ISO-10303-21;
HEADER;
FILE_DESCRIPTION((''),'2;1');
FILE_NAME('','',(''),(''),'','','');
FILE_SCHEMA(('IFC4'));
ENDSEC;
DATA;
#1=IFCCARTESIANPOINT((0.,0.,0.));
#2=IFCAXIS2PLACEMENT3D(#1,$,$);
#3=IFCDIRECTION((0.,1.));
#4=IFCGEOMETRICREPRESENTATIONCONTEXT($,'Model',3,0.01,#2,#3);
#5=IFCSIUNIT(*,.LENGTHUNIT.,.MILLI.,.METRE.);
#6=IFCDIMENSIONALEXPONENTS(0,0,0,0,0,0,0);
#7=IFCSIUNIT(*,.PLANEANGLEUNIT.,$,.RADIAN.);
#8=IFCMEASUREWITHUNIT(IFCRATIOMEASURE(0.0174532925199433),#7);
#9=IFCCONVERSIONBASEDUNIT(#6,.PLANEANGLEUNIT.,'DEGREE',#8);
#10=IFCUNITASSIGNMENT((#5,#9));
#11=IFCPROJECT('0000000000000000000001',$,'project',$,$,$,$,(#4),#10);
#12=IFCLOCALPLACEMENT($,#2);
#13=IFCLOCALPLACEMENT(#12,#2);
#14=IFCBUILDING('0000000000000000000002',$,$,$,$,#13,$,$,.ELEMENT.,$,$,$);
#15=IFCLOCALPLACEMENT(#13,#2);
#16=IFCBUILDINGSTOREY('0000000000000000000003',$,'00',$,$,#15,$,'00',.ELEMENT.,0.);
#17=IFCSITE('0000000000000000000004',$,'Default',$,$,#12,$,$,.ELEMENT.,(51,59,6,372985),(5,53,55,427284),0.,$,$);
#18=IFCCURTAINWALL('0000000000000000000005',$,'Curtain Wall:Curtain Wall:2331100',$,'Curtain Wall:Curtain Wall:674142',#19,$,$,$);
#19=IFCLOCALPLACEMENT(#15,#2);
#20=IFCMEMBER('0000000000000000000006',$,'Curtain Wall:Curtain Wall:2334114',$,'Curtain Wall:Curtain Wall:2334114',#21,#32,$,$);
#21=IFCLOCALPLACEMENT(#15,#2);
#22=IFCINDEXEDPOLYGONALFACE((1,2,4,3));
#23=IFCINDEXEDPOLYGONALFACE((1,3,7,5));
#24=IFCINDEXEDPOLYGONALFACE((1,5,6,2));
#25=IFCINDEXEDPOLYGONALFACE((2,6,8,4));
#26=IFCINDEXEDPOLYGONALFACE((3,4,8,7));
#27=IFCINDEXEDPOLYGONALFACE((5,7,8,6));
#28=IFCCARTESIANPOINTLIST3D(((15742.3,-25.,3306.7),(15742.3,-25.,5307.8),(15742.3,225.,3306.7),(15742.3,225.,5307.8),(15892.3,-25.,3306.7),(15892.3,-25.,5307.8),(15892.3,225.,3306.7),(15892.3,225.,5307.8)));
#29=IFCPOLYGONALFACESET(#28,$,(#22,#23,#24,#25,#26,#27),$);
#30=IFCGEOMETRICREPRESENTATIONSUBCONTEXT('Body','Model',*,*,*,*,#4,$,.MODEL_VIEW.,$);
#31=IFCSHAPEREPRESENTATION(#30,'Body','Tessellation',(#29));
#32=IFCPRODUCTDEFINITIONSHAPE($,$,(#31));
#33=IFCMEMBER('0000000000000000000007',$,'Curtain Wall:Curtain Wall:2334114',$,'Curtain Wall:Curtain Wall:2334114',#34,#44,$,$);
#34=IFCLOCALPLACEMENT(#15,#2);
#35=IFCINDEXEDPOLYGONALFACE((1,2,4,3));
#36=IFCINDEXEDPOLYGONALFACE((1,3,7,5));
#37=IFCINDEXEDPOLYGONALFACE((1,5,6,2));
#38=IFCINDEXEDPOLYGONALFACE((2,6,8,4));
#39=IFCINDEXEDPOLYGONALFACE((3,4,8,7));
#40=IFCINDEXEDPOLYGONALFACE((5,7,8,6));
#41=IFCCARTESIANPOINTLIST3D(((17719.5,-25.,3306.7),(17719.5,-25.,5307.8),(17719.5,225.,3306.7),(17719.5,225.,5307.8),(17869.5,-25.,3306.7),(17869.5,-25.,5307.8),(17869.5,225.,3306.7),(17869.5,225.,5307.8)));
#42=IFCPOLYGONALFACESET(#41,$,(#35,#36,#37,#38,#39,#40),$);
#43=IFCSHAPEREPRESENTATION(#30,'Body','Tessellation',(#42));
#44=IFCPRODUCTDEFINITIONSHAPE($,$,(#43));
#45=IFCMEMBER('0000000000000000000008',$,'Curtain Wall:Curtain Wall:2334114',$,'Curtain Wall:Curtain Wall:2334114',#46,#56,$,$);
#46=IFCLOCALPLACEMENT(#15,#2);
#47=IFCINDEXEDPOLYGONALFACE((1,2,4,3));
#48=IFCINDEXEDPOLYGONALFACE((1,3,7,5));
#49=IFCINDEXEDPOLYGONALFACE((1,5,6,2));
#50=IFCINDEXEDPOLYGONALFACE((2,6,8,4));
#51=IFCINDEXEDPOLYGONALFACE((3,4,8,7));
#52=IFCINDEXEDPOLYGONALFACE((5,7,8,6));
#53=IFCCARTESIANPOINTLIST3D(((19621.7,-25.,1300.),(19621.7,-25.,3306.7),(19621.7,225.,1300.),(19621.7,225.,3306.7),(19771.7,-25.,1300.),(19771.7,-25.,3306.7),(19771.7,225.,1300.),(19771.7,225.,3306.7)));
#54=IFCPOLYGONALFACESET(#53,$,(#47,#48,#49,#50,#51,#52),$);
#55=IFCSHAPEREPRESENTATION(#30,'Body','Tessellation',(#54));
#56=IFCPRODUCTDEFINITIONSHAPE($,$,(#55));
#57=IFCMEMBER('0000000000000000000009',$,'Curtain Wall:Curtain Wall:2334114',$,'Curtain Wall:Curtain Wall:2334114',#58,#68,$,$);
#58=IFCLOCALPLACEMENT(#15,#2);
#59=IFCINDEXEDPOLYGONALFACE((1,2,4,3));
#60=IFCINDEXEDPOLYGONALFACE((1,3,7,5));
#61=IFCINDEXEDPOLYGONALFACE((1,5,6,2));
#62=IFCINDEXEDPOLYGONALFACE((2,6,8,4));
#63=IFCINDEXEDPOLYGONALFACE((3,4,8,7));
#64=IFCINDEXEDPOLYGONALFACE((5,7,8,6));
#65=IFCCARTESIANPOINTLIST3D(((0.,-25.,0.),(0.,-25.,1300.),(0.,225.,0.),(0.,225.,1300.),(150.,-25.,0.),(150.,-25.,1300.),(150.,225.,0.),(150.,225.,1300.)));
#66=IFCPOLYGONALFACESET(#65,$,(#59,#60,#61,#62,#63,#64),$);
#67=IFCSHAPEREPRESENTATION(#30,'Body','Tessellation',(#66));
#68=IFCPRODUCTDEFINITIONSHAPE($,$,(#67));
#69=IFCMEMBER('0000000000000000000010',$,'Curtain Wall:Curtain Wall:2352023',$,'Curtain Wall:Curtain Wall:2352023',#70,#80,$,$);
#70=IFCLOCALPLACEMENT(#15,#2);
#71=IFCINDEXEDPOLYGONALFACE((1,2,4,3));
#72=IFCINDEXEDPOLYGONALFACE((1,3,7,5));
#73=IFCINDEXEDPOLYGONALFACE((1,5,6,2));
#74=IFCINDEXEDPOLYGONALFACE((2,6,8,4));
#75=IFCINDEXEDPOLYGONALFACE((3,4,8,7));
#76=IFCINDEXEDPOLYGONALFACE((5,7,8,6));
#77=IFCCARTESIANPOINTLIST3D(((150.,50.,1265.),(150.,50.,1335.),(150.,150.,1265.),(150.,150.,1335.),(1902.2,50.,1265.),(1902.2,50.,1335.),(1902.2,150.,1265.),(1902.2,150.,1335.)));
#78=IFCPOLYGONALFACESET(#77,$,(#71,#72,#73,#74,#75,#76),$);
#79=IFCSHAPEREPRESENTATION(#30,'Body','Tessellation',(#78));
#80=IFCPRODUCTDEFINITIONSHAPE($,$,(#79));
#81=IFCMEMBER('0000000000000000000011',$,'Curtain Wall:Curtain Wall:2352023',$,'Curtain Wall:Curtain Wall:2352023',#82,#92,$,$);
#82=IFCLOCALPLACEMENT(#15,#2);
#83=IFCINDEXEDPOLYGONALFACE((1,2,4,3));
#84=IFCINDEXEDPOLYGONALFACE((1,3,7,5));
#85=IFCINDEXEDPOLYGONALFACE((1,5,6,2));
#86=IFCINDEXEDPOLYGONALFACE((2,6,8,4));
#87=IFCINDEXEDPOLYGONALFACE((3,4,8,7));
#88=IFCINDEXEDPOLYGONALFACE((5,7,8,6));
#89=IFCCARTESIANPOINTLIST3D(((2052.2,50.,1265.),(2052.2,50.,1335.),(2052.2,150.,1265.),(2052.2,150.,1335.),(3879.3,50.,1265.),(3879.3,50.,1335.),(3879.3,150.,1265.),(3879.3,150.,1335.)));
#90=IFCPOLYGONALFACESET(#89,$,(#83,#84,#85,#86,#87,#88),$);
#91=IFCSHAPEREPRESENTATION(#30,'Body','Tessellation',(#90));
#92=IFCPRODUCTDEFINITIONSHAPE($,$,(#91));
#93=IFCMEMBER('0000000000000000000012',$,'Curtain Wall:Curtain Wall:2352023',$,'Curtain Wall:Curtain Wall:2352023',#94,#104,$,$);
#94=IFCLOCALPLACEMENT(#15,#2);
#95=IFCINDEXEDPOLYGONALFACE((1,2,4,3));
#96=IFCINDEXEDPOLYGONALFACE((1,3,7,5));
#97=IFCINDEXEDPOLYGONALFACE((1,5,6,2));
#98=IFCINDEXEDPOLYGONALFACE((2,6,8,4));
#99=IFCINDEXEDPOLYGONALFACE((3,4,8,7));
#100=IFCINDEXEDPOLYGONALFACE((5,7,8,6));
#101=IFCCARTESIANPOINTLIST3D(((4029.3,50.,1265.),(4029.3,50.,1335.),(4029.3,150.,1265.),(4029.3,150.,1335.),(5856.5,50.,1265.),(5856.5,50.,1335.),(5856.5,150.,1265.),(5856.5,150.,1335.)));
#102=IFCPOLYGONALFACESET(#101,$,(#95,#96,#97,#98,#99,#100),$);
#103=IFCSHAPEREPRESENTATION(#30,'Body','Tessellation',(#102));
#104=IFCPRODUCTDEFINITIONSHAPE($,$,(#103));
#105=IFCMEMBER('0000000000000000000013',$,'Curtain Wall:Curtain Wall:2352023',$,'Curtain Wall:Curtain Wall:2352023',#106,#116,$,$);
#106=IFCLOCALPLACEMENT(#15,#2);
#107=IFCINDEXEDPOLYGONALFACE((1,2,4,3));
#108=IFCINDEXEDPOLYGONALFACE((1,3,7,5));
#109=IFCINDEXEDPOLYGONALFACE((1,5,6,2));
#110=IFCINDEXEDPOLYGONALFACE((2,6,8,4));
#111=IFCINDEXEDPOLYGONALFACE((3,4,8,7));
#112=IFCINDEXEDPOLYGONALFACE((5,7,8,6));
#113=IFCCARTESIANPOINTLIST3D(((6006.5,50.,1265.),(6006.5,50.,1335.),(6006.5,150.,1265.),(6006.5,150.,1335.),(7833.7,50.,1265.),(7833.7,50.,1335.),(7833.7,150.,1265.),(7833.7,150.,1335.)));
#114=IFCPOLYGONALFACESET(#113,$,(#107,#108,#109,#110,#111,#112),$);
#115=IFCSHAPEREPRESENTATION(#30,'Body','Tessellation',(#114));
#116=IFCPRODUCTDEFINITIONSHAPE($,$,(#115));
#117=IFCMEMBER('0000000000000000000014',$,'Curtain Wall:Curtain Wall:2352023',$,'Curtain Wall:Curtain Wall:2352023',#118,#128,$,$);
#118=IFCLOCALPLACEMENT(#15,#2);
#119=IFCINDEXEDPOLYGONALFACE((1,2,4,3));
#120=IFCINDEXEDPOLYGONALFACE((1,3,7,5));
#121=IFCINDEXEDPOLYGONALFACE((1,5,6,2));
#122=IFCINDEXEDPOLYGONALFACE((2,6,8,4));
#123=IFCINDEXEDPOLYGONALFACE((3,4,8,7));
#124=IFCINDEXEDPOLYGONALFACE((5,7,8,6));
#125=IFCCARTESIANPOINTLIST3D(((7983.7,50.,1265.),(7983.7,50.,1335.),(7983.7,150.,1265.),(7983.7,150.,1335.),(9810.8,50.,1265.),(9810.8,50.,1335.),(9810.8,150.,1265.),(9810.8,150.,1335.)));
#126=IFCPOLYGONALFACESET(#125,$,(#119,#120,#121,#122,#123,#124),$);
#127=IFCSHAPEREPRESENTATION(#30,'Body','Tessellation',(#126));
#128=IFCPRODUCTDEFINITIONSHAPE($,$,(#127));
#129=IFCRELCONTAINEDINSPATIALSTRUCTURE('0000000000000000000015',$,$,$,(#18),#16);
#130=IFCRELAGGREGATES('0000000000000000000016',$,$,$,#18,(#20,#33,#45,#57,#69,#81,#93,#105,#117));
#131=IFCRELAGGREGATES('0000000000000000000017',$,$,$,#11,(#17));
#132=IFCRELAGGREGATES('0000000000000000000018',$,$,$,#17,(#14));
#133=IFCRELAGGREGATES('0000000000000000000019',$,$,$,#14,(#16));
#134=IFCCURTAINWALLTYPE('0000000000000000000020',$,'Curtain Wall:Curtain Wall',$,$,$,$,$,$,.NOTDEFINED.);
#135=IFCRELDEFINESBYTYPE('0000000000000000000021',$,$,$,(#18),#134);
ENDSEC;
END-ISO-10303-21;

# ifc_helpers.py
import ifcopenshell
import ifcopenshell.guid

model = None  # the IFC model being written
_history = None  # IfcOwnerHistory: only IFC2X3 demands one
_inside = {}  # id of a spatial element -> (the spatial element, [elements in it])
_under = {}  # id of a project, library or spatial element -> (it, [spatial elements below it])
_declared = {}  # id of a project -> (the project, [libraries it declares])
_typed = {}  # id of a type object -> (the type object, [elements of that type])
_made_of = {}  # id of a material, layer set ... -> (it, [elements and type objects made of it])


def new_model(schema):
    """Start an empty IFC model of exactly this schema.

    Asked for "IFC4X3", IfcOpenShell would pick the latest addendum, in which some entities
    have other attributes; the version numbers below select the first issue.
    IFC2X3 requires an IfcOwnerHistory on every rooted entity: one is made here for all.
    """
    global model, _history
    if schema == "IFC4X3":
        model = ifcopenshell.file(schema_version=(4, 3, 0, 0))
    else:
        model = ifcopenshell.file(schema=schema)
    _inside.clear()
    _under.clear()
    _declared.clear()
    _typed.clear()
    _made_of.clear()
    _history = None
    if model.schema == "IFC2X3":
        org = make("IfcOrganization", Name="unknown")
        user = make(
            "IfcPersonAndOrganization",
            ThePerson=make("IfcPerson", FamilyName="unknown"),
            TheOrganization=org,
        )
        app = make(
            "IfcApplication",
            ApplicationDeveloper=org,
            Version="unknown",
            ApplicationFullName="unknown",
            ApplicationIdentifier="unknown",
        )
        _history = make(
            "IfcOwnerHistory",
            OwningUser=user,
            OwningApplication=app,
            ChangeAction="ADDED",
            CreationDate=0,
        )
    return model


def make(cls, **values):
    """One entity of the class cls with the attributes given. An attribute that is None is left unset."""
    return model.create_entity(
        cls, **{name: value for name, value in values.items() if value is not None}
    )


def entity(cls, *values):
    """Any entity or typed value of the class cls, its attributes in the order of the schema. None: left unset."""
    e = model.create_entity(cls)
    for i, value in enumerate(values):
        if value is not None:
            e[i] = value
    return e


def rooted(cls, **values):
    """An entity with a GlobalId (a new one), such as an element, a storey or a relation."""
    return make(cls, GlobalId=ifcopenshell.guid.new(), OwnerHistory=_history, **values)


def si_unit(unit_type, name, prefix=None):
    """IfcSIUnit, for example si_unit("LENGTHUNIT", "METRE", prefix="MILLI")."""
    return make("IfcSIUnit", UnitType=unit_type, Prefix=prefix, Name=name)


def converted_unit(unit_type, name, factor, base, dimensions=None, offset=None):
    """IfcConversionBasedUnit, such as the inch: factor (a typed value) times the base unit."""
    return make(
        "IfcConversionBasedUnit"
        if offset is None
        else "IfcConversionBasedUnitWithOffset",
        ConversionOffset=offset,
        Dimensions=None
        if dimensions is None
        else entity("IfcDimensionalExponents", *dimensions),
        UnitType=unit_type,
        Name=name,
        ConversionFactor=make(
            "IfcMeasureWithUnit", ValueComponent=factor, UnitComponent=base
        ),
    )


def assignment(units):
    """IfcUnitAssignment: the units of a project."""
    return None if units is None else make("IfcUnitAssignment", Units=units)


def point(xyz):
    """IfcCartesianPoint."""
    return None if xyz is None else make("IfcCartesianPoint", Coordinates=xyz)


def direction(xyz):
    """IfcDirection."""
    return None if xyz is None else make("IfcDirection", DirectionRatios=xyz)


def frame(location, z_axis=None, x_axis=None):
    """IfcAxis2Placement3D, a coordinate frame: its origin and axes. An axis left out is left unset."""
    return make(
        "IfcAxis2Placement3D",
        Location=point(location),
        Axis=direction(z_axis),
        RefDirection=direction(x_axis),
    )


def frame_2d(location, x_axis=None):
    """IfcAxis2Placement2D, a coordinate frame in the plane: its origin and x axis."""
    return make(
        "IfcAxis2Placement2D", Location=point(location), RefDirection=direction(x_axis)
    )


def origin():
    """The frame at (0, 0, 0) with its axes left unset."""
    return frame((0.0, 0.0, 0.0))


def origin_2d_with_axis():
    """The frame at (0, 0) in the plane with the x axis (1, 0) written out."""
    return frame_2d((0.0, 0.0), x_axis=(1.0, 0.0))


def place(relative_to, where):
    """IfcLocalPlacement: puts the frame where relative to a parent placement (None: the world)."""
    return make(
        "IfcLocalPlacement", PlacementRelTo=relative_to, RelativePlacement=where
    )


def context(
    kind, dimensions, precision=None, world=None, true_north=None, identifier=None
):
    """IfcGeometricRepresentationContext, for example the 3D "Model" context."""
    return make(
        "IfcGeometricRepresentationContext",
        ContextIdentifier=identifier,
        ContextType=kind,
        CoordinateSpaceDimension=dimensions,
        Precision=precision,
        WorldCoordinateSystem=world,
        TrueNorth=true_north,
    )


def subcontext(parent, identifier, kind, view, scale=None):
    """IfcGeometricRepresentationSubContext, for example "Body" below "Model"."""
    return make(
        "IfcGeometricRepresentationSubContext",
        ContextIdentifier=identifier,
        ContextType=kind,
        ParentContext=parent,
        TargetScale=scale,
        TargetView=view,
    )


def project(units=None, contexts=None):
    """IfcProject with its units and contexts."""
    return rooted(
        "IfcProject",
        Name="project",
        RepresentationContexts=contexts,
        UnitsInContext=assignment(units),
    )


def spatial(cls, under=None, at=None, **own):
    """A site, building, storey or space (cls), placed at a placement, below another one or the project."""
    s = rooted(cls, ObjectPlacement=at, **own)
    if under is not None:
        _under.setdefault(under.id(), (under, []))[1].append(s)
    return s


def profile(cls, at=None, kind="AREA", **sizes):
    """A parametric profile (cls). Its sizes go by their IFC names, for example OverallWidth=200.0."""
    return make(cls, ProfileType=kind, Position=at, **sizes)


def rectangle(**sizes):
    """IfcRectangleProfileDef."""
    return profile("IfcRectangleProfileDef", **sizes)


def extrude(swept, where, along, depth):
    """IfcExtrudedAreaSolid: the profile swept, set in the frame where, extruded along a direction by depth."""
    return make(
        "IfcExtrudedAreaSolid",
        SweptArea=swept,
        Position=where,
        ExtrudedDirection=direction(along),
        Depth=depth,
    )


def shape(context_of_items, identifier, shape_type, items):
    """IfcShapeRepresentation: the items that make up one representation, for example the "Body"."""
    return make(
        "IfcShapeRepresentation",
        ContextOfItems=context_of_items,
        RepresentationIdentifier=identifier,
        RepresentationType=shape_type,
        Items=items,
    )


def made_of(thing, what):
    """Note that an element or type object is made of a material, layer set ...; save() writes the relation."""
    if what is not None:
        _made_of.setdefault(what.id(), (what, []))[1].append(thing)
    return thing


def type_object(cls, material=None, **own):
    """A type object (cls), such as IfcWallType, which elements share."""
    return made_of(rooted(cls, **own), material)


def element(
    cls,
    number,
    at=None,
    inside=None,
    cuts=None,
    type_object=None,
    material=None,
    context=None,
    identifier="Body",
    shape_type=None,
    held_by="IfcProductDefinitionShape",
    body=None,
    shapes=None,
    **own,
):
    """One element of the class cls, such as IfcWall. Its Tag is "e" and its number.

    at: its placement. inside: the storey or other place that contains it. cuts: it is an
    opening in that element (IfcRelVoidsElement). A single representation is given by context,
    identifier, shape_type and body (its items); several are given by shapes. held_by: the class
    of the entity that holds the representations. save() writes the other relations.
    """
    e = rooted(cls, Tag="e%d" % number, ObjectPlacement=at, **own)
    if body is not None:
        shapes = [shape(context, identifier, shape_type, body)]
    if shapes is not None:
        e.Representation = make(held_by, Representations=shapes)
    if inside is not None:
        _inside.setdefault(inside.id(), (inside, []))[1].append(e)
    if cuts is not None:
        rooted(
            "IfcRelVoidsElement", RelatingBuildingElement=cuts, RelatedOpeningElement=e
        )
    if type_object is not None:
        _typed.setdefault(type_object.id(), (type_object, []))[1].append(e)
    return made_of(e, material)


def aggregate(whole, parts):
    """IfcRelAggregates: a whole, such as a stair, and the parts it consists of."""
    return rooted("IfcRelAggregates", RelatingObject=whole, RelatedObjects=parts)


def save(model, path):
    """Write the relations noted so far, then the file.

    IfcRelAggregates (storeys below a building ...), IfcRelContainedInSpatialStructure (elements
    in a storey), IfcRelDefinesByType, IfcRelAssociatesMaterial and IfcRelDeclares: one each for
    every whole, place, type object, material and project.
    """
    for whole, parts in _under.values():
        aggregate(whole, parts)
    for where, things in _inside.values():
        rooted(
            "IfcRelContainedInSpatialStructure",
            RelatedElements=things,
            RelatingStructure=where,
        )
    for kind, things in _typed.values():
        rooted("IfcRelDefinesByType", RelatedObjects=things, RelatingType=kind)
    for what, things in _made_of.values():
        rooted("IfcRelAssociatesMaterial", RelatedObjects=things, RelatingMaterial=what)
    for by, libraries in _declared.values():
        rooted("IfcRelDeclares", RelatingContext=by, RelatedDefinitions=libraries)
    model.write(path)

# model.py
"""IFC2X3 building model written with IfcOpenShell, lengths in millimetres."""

from ifc_helpers import new_model, entity, si_unit, converted_unit, direction, frame, frame_2d, origin, origin_2d_with_axis, place, context, subcontext, project, spatial, rectangle, extrude, type_object, element, aggregate, save


model = new_model("IFC2X3")

# Units and contexts
model_context = context("Model", 3, precision=0.01, world=origin(), true_north=direction((0.0, 1.0)))
body_context = subcontext(model_context, "Body", "Model", "MODEL_VIEW")
ifc_project = project(units=[si_unit("LENGTHUNIT", "METRE", prefix="MILLI"), converted_unit("PLANEANGLEUNIT", "DEGREE", entity("IfcRatioMeasure", 0.0174532925199433), si_unit("PLANEANGLEUNIT", "RADIAN"), dimensions=[0, 0, 0, 0, 0, 0, 0])], contexts=[model_context])

# Site, building, storey
site_placement = place(None, origin())
site = spatial("IfcSite", under=ifc_project, at=site_placement, Name="Default", CompositionType="ELEMENT", RefLatitude=(51, 59, 6, 372985), RefLongitude=(5, 53, 55, 427284), RefElevation=0.0)
building_placement = place(site_placement, origin())
building = spatial("IfcBuilding", under=site, at=building_placement, CompositionType="ELEMENT")
storey_placement = place(building_placement, origin())
storey = spatial("IfcBuildingStorey", under=building, at=storey_placement, Name="00", LongName="00", CompositionType="ELEMENT", Elevation=0.0)

# Curtain wall, members
curtain_wall_type = type_object("IfcCurtainWallType", Name="Curtain Wall:Curtain Wall", PredefinedType="NOTDEFINED")
curtain_wall_placement = place(storey_placement, origin())
curtain_wall = element("IfcCurtainWall", 1, at=curtain_wall_placement, inside=storey, type_object=curtain_wall_type, Name="Curtain Wall:Curtain Wall:2331100", ObjectType="Curtain Wall:Curtain Wall:674142")
member_1_placement = place(curtain_wall_placement, origin())
member_1 = element("IfcMember", 2, at=member_1_placement, Name="Curtain Wall:Curtain Wall:2334114", ObjectType="Curtain Wall:Curtain Wall:2334114", context=body_context, shape_type="SweptSolid", body=[
    extrude(rectangle(XDim=150.0, YDim=250.0, at=frame_2d((0.0, 0.0), x_axis=(1.0, 0.0))), frame((15817.3, 100.0, 3306.7), z_axis=(0.0, 0.0, 1.0), x_axis=(-1.0, 0.0, 0.0)), (0.0, 0.0, 1.0), 2001.1),
])
member_2_placement = place(curtain_wall_placement, origin())
member_2 = element("IfcMember", 3, at=member_2_placement, Name="Curtain Wall:Curtain Wall:2334114", ObjectType="Curtain Wall:Curtain Wall:2334114", context=body_context, shape_type="SweptSolid", body=[
    extrude(rectangle(XDim=150.0, YDim=250.0, at=origin_2d_with_axis()), frame((17794.5, 100.0, 3306.7), z_axis=(0.0, 0.0, 1.0), x_axis=(-1.0, 0.0, 0.0)), (0.0, 0.0, 1.0), 2001.1),
])
member_3_placement = place(curtain_wall_placement, origin())
member_3 = element("IfcMember", 4, at=member_3_placement, Name="Curtain Wall:Curtain Wall:2334114", ObjectType="Curtain Wall:Curtain Wall:2334114", context=body_context, shape_type="SweptSolid", body=[
    extrude(rectangle(XDim=150.0, YDim=250.0, at=origin_2d_with_axis()), frame((19696.7, 100.0, 1300.0), z_axis=(0.0, 0.0, 1.0), x_axis=(-1.0, 0.0, 0.0)), (0.0, 0.0, 1.0), 2006.7),
])
member_4_placement = place(curtain_wall_placement, origin())
member_4 = element("IfcMember", 5, at=member_4_placement, Name="Curtain Wall:Curtain Wall:2334114", ObjectType="Curtain Wall:Curtain Wall:2334114", context=body_context, shape_type="SweptSolid", body=[
    extrude(rectangle(XDim=150.0, YDim=250.0, at=origin_2d_with_axis()), frame((75.0, 100.0, 1300.0), z_axis=(0.0, 0.0, -1.0), x_axis=(-1.0, 0.0, 0.0)), (0.0, 0.0, 1.0), 1300.0),
])
member_5_placement = place(curtain_wall_placement, origin())
member_5 = element("IfcMember", 6, at=member_5_placement, Name="Curtain Wall:Curtain Wall:2352023", ObjectType="Curtain Wall:Curtain Wall:2352023", context=body_context, shape_type="SweptSolid", body=[
    extrude(rectangle(XDim=70.0, YDim=100.0, at=frame_2d((0.0, 0.0), x_axis=(1.0, 0.0))), frame((1902.2, 100.0, 1300.0), z_axis=(-1.0, 0.0, 0.0), x_axis=(0.0, 0.0, -1.0)), (0.0, 0.0, 1.0), 1752.2),
])
member_6_placement = place(curtain_wall_placement, origin())
member_6 = element("IfcMember", 7, at=member_6_placement, Name="Curtain Wall:Curtain Wall:2352023", ObjectType="Curtain Wall:Curtain Wall:2352023", context=body_context, shape_type="SweptSolid", body=[
    extrude(rectangle(XDim=70.0, YDim=100.0, at=frame_2d((0.0, 0.0), x_axis=(1.0, 0.0))), frame((3879.3, 100.0, 1300.0), z_axis=(-1.0, 0.0, 0.0), x_axis=(0.0, 0.0, -1.0)), (0.0, 0.0, 1.0), 1827.2),
])
member_7_placement = place(curtain_wall_placement, origin())
member_7 = element("IfcMember", 8, at=member_7_placement, Name="Curtain Wall:Curtain Wall:2352023", ObjectType="Curtain Wall:Curtain Wall:2352023", context=body_context, shape_type="SweptSolid", body=[
    extrude(rectangle(XDim=70.0, YDim=100.0, at=frame_2d((0.0, 0.0), x_axis=(1.0, 0.0))), frame((5856.5, 100.0, 1300.0), z_axis=(-1.0, 0.0, 0.0), x_axis=(0.0, 0.0, -1.0)), (0.0, 0.0, 1.0), 1827.2),
])
member_8_placement = place(curtain_wall_placement, origin())
member_8 = element("IfcMember", 9, at=member_8_placement, Name="Curtain Wall:Curtain Wall:2352023", ObjectType="Curtain Wall:Curtain Wall:2352023", context=body_context, shape_type="SweptSolid", body=[
    extrude(rectangle(XDim=70.0, YDim=100.0, at=frame_2d((0.0, 0.0), x_axis=(1.0, 0.0))), frame((7833.7, 100.0, 1300.0), z_axis=(-1.0, 0.0, 0.0), x_axis=(0.0, 0.0, -1.0)), (0.0, 0.0, 1.0), 1827.2),
])
member_9_placement = place(curtain_wall_placement, origin())
member_9 = element("IfcMember", 10, at=member_9_placement, Name="Curtain Wall:Curtain Wall:2352023", ObjectType="Curtain Wall:Curtain Wall:2352023", context=body_context, shape_type="SweptSolid", body=[
    extrude(rectangle(XDim=70.0, YDim=100.0, at=frame_2d((0.0, 0.0), x_axis=(1.0, 0.0))), frame((9810.8, 100.0, 1300.0), z_axis=(-1.0, 0.0, 0.0), x_axis=(0.0, 0.0, -1.0)), (0.0, 0.0, 1.0), 1827.2),
])
aggregate(curtain_wall, [member_1, member_2, member_3, member_4, member_5, member_6, member_7, member_8, member_9])

save(model, "model.ifc")
